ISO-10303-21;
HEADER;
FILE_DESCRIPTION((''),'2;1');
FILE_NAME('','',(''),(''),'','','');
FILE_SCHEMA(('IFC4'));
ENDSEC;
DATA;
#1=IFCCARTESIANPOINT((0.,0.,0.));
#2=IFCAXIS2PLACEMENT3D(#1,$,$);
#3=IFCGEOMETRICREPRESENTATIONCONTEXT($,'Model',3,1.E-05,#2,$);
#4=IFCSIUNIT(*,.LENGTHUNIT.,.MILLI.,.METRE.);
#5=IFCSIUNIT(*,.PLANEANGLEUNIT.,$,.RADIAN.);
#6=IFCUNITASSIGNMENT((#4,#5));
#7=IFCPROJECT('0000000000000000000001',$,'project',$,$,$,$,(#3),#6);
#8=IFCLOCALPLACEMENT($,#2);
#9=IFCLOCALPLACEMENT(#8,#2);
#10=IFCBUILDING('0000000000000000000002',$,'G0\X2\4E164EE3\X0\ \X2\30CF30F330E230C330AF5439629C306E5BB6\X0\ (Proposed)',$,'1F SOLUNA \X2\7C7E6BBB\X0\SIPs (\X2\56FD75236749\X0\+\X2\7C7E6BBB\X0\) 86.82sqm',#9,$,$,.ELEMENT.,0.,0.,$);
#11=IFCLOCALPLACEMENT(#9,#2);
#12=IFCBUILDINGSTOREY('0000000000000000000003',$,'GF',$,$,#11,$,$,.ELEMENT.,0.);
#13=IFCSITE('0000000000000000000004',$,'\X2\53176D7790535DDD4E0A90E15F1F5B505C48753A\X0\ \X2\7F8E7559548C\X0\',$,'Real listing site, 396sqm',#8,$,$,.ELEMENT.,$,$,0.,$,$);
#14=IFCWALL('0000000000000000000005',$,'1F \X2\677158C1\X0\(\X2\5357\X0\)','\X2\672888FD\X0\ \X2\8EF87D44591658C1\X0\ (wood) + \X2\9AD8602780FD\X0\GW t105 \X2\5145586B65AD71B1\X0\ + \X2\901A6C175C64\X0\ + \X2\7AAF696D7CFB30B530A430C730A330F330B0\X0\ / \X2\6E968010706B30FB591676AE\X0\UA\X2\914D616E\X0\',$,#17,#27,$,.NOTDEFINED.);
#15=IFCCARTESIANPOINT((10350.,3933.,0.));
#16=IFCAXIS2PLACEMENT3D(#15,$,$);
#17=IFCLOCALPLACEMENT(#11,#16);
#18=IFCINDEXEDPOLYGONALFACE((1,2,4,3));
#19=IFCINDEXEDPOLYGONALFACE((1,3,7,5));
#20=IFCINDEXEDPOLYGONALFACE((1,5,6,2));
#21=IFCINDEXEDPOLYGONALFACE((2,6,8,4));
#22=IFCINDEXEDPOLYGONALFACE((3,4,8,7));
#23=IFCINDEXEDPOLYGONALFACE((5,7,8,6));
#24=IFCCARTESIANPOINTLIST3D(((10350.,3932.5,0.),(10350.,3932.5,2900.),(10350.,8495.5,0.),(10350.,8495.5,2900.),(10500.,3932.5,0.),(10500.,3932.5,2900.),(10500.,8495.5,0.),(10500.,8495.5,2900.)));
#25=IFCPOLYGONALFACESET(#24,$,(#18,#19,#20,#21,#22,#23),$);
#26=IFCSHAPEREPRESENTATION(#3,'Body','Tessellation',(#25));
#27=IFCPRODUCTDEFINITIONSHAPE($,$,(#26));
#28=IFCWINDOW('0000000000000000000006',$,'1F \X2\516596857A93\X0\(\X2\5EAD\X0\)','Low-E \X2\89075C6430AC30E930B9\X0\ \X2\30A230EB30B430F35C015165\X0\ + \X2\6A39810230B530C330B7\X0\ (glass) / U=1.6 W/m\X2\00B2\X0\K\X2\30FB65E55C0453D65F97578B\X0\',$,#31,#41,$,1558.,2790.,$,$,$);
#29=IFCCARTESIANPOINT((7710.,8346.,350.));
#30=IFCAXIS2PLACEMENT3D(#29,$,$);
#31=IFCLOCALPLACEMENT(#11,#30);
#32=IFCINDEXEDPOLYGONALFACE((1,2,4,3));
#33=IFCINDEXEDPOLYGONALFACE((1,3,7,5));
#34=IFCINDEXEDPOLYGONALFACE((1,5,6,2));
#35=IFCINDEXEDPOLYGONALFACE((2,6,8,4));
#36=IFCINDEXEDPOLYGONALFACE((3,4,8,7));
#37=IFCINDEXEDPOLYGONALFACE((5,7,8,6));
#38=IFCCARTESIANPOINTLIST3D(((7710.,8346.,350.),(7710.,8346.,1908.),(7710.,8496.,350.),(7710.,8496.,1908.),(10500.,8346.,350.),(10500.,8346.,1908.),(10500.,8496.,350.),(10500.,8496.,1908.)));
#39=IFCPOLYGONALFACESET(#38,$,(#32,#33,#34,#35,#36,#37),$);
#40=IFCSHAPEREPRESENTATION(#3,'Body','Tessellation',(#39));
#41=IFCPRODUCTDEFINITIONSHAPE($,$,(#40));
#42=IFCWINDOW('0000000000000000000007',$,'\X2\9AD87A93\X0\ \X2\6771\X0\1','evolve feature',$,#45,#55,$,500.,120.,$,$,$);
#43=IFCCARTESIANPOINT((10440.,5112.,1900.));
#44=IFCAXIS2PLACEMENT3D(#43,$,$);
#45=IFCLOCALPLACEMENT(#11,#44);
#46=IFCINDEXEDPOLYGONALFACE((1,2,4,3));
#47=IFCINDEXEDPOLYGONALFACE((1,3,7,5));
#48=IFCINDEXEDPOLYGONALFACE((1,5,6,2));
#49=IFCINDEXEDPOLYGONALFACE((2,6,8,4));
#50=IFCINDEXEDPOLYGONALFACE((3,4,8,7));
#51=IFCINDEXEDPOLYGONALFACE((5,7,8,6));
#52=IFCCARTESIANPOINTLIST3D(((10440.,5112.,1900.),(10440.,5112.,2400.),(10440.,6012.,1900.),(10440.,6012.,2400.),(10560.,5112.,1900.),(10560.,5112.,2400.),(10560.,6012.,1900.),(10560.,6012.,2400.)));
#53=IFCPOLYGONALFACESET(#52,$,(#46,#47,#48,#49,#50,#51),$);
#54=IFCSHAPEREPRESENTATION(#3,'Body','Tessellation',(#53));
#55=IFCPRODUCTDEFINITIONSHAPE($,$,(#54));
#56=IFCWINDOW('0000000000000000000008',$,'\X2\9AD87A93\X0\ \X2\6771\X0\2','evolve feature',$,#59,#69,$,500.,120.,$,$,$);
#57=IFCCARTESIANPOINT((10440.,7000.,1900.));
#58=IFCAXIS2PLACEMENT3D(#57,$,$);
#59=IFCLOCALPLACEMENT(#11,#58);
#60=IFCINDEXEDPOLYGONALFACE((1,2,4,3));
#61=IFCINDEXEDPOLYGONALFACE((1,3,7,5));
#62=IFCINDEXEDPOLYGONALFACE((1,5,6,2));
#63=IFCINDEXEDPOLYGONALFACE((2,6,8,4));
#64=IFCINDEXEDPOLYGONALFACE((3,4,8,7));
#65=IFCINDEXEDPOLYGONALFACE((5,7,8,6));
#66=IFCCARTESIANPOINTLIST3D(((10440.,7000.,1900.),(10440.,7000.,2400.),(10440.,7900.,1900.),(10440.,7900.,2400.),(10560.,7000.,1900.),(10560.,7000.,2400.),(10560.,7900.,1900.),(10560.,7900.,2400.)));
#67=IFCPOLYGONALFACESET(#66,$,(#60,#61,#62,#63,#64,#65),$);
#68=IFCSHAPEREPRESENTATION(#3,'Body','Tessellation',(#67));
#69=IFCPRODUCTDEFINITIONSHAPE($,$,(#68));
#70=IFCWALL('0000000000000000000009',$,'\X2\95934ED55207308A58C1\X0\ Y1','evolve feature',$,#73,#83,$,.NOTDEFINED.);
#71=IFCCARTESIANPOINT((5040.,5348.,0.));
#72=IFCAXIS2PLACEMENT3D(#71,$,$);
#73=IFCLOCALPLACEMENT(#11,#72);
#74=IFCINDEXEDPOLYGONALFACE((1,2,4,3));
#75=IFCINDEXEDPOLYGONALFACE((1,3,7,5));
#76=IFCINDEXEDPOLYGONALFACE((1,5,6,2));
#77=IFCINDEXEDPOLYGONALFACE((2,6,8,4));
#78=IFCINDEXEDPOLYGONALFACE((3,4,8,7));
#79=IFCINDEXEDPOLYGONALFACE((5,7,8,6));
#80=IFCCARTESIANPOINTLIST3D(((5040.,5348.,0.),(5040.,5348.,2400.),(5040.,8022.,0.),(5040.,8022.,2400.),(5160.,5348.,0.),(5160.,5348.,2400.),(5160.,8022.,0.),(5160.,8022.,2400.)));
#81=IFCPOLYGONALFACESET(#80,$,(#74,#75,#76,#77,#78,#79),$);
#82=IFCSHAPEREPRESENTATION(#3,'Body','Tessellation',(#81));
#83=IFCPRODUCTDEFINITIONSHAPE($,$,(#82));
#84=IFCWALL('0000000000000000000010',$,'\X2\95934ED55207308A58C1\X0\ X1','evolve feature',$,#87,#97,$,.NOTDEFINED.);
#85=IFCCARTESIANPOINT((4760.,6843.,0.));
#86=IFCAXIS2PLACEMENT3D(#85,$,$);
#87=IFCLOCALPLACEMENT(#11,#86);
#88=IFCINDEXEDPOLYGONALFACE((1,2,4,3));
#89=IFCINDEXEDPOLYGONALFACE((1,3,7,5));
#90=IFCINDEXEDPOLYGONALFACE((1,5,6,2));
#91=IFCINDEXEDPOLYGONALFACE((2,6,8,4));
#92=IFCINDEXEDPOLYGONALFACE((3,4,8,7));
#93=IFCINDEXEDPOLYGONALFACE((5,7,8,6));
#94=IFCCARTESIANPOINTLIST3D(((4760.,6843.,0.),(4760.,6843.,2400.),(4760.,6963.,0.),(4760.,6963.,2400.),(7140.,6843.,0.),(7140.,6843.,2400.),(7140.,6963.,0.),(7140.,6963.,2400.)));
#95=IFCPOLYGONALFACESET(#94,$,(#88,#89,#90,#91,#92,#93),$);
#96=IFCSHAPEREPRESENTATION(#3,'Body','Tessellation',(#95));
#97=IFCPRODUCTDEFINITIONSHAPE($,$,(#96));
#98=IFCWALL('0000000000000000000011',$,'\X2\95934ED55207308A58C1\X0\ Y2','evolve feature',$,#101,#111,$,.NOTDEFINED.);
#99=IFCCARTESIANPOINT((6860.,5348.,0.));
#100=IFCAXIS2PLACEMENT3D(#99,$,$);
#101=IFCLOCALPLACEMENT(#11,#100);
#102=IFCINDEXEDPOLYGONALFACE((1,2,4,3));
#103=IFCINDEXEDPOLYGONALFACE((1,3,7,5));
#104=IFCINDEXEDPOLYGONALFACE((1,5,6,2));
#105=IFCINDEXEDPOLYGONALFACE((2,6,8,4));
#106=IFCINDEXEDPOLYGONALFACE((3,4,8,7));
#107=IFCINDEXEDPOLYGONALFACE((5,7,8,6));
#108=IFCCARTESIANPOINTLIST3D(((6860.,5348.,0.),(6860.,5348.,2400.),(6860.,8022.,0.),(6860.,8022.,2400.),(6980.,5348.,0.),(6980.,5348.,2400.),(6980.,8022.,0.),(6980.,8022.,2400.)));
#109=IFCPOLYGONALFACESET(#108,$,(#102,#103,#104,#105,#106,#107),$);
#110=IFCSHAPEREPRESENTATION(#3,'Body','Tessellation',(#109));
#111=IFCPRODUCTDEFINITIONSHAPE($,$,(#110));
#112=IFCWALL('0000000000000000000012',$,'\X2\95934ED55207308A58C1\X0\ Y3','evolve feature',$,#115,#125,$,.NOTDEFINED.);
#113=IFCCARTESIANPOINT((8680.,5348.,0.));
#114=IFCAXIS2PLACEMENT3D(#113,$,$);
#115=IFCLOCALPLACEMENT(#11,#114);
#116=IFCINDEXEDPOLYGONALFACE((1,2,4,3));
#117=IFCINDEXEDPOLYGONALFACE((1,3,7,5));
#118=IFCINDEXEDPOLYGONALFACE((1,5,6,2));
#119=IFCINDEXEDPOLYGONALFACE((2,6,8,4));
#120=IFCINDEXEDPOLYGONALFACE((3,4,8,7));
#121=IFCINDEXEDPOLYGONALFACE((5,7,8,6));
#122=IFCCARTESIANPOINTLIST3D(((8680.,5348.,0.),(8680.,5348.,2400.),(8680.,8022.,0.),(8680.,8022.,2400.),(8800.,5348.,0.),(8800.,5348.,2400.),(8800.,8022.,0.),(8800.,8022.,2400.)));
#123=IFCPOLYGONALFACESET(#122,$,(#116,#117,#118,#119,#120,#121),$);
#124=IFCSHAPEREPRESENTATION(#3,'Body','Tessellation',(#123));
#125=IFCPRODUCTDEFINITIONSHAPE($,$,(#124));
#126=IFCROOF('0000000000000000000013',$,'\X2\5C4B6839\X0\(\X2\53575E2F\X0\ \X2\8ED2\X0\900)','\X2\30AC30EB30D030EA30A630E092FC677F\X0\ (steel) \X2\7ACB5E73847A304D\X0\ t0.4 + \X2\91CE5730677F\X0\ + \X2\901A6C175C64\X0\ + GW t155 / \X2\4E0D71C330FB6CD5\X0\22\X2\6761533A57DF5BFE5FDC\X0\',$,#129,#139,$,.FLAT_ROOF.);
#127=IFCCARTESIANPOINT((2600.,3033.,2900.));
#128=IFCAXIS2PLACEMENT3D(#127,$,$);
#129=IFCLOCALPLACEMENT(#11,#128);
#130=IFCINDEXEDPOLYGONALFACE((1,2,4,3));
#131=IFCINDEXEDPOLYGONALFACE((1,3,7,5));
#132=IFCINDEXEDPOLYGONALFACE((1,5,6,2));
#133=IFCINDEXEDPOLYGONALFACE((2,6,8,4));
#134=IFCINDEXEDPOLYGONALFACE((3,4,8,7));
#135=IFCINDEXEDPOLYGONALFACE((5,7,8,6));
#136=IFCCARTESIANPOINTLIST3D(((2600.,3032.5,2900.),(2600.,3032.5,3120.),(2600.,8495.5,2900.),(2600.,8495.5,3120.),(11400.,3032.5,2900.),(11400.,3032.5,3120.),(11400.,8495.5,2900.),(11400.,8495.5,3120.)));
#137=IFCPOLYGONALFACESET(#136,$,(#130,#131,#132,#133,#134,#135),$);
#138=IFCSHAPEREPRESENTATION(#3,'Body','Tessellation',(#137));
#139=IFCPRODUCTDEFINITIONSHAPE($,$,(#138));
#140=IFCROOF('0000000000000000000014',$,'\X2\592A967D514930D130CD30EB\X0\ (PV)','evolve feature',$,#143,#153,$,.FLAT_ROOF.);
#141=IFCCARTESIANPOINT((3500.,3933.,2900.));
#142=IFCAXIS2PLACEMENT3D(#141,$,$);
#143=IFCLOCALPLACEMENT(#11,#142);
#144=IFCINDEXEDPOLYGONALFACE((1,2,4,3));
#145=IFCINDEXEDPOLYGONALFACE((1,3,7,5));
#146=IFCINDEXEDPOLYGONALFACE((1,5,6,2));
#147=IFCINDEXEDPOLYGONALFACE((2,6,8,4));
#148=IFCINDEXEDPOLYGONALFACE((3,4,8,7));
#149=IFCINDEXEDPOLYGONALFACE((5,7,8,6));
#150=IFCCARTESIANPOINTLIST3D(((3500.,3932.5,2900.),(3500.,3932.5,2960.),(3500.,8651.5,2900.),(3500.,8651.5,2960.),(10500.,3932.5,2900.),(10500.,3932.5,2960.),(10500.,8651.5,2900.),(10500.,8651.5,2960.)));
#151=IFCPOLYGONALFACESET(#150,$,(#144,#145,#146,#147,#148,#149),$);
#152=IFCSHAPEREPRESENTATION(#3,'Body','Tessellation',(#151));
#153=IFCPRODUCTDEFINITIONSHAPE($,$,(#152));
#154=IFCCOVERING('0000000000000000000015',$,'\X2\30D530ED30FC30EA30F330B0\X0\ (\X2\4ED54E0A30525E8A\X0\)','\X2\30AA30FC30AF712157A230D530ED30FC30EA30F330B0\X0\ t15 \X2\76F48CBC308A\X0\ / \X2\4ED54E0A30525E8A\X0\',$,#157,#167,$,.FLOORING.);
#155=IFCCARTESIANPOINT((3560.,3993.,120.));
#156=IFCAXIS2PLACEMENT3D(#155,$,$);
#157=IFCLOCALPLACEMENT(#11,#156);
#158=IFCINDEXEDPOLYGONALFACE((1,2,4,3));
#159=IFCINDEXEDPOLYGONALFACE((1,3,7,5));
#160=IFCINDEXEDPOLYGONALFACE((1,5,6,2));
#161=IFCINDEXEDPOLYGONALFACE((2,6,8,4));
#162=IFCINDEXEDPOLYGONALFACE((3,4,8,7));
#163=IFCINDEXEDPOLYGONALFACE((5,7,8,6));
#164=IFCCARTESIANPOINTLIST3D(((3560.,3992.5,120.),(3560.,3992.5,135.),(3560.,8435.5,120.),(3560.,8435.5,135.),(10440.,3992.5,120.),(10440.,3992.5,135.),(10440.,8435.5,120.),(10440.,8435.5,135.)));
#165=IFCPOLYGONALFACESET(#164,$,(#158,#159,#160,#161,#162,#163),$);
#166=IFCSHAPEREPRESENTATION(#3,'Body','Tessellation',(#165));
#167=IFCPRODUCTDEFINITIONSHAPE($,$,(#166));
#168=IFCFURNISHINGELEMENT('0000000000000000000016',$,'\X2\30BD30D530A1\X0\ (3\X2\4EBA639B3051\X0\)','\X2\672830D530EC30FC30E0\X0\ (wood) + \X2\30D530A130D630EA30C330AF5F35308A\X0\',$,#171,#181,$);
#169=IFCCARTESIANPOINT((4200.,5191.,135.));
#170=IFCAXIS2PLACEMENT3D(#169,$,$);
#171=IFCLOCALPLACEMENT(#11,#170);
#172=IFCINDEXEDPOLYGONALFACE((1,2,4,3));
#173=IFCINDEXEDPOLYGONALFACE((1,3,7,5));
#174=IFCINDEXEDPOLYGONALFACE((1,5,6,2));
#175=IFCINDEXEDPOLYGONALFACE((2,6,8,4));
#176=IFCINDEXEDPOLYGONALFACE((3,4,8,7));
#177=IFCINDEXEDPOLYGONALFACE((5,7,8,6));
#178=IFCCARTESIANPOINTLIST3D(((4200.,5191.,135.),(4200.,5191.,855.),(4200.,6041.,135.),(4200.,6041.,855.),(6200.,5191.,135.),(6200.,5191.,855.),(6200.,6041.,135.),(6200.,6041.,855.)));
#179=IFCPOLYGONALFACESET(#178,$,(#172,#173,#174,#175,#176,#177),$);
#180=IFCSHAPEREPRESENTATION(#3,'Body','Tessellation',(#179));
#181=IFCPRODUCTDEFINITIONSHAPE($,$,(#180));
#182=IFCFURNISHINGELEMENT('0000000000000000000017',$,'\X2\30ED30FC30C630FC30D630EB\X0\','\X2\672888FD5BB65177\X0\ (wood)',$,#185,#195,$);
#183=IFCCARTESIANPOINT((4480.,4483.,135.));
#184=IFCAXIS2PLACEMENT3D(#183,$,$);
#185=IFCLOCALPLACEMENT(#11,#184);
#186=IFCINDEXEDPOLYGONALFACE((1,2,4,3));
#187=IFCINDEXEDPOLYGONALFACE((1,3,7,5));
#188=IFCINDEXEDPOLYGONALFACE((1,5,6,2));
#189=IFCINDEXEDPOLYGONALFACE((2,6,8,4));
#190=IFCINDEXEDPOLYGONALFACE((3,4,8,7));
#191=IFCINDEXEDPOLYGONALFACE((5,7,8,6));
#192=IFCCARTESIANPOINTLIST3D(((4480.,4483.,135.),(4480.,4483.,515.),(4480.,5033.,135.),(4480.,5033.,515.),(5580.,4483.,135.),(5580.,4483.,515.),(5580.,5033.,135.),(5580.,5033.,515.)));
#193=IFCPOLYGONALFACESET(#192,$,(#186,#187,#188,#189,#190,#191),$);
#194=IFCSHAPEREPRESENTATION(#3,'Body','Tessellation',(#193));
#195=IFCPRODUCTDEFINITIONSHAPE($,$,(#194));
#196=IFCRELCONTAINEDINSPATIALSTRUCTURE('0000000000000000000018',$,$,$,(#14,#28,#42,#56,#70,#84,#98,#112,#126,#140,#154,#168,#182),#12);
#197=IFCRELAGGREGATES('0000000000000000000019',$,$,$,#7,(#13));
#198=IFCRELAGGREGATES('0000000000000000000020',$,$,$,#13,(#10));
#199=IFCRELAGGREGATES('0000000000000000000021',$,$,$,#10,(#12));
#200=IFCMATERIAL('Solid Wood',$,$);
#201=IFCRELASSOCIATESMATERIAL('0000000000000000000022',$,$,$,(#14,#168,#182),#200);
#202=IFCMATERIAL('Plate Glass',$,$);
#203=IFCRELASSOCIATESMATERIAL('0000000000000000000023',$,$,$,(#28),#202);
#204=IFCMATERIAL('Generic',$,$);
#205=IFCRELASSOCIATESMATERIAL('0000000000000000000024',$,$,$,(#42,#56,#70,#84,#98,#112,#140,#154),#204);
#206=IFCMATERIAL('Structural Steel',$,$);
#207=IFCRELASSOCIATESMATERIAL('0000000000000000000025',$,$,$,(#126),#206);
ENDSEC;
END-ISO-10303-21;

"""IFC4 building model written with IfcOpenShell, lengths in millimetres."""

from ifc_helpers import new_model, si_unit, frame, frame_2d, origin, place, context, project, spatial, rectangle, extrude, material, element, fill, save


model = new_model("IFC4")

# Units and contexts
model_context = context("Model", 3, precision=1e-05, world=origin())
ifc_project = project(units=[si_unit("LENGTHUNIT", "METRE", prefix="MILLI"), si_unit("PLANEANGLEUNIT", "RADIAN")], contexts=[model_context])

# Site, building, storey
site_placement = place(None, origin())
site = spatial("IfcSite", under=ifc_project, at=site_placement, Name="北海道川上郡弟子屈町 美留和", ObjectType="Real listing site, 396sqm", CompositionType="ELEMENT", RefElevation=0.0)
building_placement = place(site_placement, origin())
building = spatial("IfcBuilding", under=site, at=building_placement, Name="G0世代 ハンモック吹抜の家 (Proposed)", ObjectType="1F SOLUNA 籾殻SIPs (国産杉+籾殻) 86.82sqm", CompositionType="ELEMENT", ElevationOfRefHeight=0.0, ElevationOfTerrain=0.0)
storey_placement = place(building_placement, origin())
storey = spatial("IfcBuildingStorey", under=building, at=storey_placement, Name="GF", CompositionType="ELEMENT", Elevation=0.0)

# Shared definitions
ifc_material_1 = material(Name="Solid Wood")
ifc_material_2 = material(Name="Generic")

# Shared definitions
ifc_material_3 = material(Name="Plate Glass")

# Wall, openings, windows
wall_1_placement = place(storey_placement, frame((10350.0, 3933.0, 0.0)))
wall_1 = element("IfcWall", 1, at=wall_1_placement, inside=storey, material=ifc_material_1, Name="1F 東壁(南)", Description="木製 軸組外壁 (wood) + 高性能GW t105 充填断熱 + 通気層 + 窯業系サイディング / 準耐火・外皮UA配慮", PredefinedType="NOTDEFINED", context=model_context, shape_type="SweptSolid", body=[
    extrude(rectangle(XDim=150.0, YDim=4563.0, at=frame_2d((75.0, 2281.0))), frame((10350.0, 3933.0, 0.0)), (0.0, 0.0, 1.0), 2900.0),
])
opening_1_placement = place(storey_placement, frame((7710.0, 8346.0, 350.0)))
opening_1 = element("IfcOpeningElement", 2, at=opening_1_placement, cuts=wall_1, PredefinedType="NOTDEFINED", context=model_context, shape_type="SweptSolid", body=[
    extrude(rectangle(XDim=2790.0, YDim=150.0, at=frame_2d((1395.0, 75.0))), frame((7710.0, 8346.0, 350.0)), (0.0, 0.0, 1.0), 1558.0),
])
opening_2_placement = place(storey_placement, frame((10440.0, 5112.0, 1900.0)))
opening_2 = element("IfcOpeningElement", 3, at=opening_2_placement, cuts=wall_1, PredefinedType="NOTDEFINED", context=model_context, shape_type="SweptSolid", body=[
    extrude(rectangle(XDim=120.0, YDim=900.0, at=frame_2d((60.0, 450.0))), frame((10440.0, 5112.0, 1900.0)), (0.0, 0.0, 1.0), 500.0),
])
opening_3_placement = place(storey_placement, frame((10440.0, 7000.0, 1900.0)))
opening_3 = element("IfcOpeningElement", 4, at=opening_3_placement, cuts=wall_1, PredefinedType="NOTDEFINED", context=model_context, shape_type="SweptSolid", body=[
    extrude(rectangle(XDim=120.0, YDim=900.0, at=frame_2d((60.0, 450.0))), frame((10440.0, 7000.0, 1900.0)), (0.0, 0.0, 1.0), 500.0),
])
window_1_placement = place(storey_placement, frame((7710.0, 8346.0, 350.0)))
window_1 = element("IfcWindow", 5, at=window_1_placement, inside=storey, material=ifc_material_3, Name="1F 入隅窓(庭)", Description="Low-E 複層ガラス アルゴン封入 + 樹脂サッシ (glass) / U=1.6 W/m²K・日射取得型", OverallHeight=1558.0, OverallWidth=2790.0, context=model_context, shape_type="SweptSolid", body=[
    extrude(rectangle(XDim=2790.0, YDim=150.0, at=frame_2d((1395.0, 75.0))), frame((7710.0, 8346.0, 350.0)), (0.0, 0.0, 1.0), 1558.0),
])
fill(opening_1, window_1)
window_2_placement = place(storey_placement, frame((10440.0, 5112.0, 1900.0)))
window_2 = element("IfcWindow", 6, at=window_2_placement, inside=storey, material=ifc_material_2, Name="高窓 東1", Description="evolve feature", OverallHeight=500.0, OverallWidth=120.0, context=model_context, shape_type="SweptSolid", body=[
    extrude(rectangle(XDim=120.0, YDim=900.0, at=frame_2d((60.0, 450.0))), frame((10440.0, 5112.0, 1900.0)), (0.0, 0.0, 1.0), 500.0),
])
fill(opening_2, window_2)
window_3_placement = place(storey_placement, frame((10440.0, 7000.0, 1900.0)))
window_3 = element("IfcWindow", 7, at=window_3_placement, inside=storey, material=ifc_material_2, Name="高窓 東2", Description="evolve feature", OverallHeight=500.0, OverallWidth=120.0, context=model_context, shape_type="SweptSolid", body=[
    extrude(rectangle(XDim=120.0, YDim=900.0, at=frame_2d((60.0, 450.0))), frame((10440.0, 7000.0, 1900.0)), (0.0, 0.0, 1.0), 500.0),
])
fill(opening_3, window_3)

# Walls
wall_2_placement = place(storey_placement, frame((5040.0, 5348.0, 0.0)))
element("IfcWall", 8, at=wall_2_placement, inside=storey, material=ifc_material_2, Name="間仕切り壁 Y1", Description="evolve feature", PredefinedType="NOTDEFINED", context=model_context, shape_type="SweptSolid", body=[
    extrude(rectangle(XDim=120.0, YDim=2674.0, at=frame_2d((60.0, 1337.0))), frame((5040.0, 5348.0, 0.0)), (0.0, 0.0, 1.0), 2400.0),
])
wall_3_placement = place(storey_placement, frame((4760.0, 6843.0, 0.0)))
element("IfcWall", 9, at=wall_3_placement, inside=storey, material=ifc_material_2, Name="間仕切り壁 X1", Description="evolve feature", PredefinedType="NOTDEFINED", context=model_context, shape_type="SweptSolid", body=[
    extrude(rectangle(XDim=2380.0, YDim=120.0, at=frame_2d((1190.0, 60.0))), frame((4760.0, 6843.0, 0.0)), (0.0, 0.0, 1.0), 2400.0),
])
wall_4_placement = place(storey_placement, frame((6860.0, 5348.0, 0.0)))
element("IfcWall", 10, at=wall_4_placement, inside=storey, material=ifc_material_2, Name="間仕切り壁 Y2", Description="evolve feature", PredefinedType="NOTDEFINED", context=model_context, shape_type="SweptSolid", body=[
    extrude(rectangle(XDim=120.0, YDim=2674.0, at=frame_2d((60.0, 1337.0))), frame((6860.0, 5348.0, 0.0)), (0.0, 0.0, 1.0), 2400.0),
])
wall_5_placement = place(storey_placement, frame((8680.0, 5348.0, 0.0)))
element("IfcWall", 11, at=wall_5_placement, inside=storey, material=ifc_material_2, Name="間仕切り壁 Y3", Description="evolve feature", PredefinedType="NOTDEFINED", context=model_context, shape_type="SweptSolid", body=[
    extrude(rectangle(XDim=120.0, YDim=2674.0, at=frame_2d((60.0, 1337.0))), frame((8680.0, 5348.0, 0.0)), (0.0, 0.0, 1.0), 2400.0),
])

# Roofs
ifc_material_4 = material(Name="Structural Steel")
roof_1_placement = place(storey_placement, frame((2600.0, 3033.0, 2900.0)))
element("IfcRoof", 12, at=roof_1_placement, inside=storey, material=ifc_material_4, Name="屋根(南帯 軒900)", Description="ガルバリウム鋼板 (steel) 立平葺き t0.4 + 野地板 + 通気層 + GW t155 / 不燃・法22条区域対応", PredefinedType="FLAT_ROOF", context=model_context, shape_type="SweptSolid", body=[
    extrude(rectangle(XDim=8800.0, YDim=5463.0, at=frame_2d((4400.0, 2731.0))), frame((2600.0, 3033.0, 2900.0)), (0.0, 0.0, 1.0), 220.0),
])
roof_2_placement = place(storey_placement, frame((3500.0, 3933.0, 2900.0)))
element("IfcRoof", 13, at=roof_2_placement, inside=storey, material=ifc_material_2, Name="太陽光パネル (PV)", Description="evolve feature", PredefinedType="FLAT_ROOF", context=model_context, shape_type="SweptSolid", body=[
    extrude(rectangle(XDim=7000.0, YDim=4719.0, at=frame_2d((3500.0, 2359.0))), frame((3500.0, 3933.0, 2900.0)), (0.0, 0.0, 1.0), 60.0),
])

# Covering
covering_placement = place(storey_placement, frame((3560.0, 3993.0, 120.0)))
element("IfcCovering", 14, at=covering_placement, inside=storey, material=ifc_material_2, Name="フローリング (仕上げ床)", Description="オーク無垢フローリング t15 直貼り / 仕上げ床", PredefinedType="FLOORING", context=model_context, shape_type="SweptSolid", body=[
    extrude(rectangle(XDim=6880.0, YDim=4443.0, at=frame_2d((3440.0, 2221.0))), frame((3560.0, 3993.0, 120.0)), (0.0, 0.0, 1.0), 15.0),
])

# Furnishing elements
furnishing_1_placement = place(storey_placement, frame((4200.0, 5191.0, 135.0)))
element("IfcFurnishingElement", 15, at=furnishing_1_placement, inside=storey, material=ifc_material_1, Name="ソファ (3人掛け)", Description="木フレーム (wood) + ファブリック張り", context=model_context, shape_type="SweptSolid", body=[
    extrude(rectangle(XDim=2000.0, YDim=850.0, at=frame_2d((1000.0, 425.0))), frame((4200.0, 5191.0, 135.0)), (0.0, 0.0, 1.0), 720.0),
])
furnishing_2_placement = place(storey_placement, frame((4480.0, 4483.0, 135.0)))
element("IfcFurnishingElement", 16, at=furnishing_2_placement, inside=storey, material=ifc_material_1, Name="ローテーブル", Description="木製家具 (wood)", context=model_context, shape_type="SweptSolid", body=[
    extrude(rectangle(XDim=1100.0, YDim=550.0, at=frame_2d((550.0, 275.0))), frame((4480.0, 4483.0, 135.0)), (0.0, 0.0, 1.0), 380.0),
])

save(model, "model.ifc")
